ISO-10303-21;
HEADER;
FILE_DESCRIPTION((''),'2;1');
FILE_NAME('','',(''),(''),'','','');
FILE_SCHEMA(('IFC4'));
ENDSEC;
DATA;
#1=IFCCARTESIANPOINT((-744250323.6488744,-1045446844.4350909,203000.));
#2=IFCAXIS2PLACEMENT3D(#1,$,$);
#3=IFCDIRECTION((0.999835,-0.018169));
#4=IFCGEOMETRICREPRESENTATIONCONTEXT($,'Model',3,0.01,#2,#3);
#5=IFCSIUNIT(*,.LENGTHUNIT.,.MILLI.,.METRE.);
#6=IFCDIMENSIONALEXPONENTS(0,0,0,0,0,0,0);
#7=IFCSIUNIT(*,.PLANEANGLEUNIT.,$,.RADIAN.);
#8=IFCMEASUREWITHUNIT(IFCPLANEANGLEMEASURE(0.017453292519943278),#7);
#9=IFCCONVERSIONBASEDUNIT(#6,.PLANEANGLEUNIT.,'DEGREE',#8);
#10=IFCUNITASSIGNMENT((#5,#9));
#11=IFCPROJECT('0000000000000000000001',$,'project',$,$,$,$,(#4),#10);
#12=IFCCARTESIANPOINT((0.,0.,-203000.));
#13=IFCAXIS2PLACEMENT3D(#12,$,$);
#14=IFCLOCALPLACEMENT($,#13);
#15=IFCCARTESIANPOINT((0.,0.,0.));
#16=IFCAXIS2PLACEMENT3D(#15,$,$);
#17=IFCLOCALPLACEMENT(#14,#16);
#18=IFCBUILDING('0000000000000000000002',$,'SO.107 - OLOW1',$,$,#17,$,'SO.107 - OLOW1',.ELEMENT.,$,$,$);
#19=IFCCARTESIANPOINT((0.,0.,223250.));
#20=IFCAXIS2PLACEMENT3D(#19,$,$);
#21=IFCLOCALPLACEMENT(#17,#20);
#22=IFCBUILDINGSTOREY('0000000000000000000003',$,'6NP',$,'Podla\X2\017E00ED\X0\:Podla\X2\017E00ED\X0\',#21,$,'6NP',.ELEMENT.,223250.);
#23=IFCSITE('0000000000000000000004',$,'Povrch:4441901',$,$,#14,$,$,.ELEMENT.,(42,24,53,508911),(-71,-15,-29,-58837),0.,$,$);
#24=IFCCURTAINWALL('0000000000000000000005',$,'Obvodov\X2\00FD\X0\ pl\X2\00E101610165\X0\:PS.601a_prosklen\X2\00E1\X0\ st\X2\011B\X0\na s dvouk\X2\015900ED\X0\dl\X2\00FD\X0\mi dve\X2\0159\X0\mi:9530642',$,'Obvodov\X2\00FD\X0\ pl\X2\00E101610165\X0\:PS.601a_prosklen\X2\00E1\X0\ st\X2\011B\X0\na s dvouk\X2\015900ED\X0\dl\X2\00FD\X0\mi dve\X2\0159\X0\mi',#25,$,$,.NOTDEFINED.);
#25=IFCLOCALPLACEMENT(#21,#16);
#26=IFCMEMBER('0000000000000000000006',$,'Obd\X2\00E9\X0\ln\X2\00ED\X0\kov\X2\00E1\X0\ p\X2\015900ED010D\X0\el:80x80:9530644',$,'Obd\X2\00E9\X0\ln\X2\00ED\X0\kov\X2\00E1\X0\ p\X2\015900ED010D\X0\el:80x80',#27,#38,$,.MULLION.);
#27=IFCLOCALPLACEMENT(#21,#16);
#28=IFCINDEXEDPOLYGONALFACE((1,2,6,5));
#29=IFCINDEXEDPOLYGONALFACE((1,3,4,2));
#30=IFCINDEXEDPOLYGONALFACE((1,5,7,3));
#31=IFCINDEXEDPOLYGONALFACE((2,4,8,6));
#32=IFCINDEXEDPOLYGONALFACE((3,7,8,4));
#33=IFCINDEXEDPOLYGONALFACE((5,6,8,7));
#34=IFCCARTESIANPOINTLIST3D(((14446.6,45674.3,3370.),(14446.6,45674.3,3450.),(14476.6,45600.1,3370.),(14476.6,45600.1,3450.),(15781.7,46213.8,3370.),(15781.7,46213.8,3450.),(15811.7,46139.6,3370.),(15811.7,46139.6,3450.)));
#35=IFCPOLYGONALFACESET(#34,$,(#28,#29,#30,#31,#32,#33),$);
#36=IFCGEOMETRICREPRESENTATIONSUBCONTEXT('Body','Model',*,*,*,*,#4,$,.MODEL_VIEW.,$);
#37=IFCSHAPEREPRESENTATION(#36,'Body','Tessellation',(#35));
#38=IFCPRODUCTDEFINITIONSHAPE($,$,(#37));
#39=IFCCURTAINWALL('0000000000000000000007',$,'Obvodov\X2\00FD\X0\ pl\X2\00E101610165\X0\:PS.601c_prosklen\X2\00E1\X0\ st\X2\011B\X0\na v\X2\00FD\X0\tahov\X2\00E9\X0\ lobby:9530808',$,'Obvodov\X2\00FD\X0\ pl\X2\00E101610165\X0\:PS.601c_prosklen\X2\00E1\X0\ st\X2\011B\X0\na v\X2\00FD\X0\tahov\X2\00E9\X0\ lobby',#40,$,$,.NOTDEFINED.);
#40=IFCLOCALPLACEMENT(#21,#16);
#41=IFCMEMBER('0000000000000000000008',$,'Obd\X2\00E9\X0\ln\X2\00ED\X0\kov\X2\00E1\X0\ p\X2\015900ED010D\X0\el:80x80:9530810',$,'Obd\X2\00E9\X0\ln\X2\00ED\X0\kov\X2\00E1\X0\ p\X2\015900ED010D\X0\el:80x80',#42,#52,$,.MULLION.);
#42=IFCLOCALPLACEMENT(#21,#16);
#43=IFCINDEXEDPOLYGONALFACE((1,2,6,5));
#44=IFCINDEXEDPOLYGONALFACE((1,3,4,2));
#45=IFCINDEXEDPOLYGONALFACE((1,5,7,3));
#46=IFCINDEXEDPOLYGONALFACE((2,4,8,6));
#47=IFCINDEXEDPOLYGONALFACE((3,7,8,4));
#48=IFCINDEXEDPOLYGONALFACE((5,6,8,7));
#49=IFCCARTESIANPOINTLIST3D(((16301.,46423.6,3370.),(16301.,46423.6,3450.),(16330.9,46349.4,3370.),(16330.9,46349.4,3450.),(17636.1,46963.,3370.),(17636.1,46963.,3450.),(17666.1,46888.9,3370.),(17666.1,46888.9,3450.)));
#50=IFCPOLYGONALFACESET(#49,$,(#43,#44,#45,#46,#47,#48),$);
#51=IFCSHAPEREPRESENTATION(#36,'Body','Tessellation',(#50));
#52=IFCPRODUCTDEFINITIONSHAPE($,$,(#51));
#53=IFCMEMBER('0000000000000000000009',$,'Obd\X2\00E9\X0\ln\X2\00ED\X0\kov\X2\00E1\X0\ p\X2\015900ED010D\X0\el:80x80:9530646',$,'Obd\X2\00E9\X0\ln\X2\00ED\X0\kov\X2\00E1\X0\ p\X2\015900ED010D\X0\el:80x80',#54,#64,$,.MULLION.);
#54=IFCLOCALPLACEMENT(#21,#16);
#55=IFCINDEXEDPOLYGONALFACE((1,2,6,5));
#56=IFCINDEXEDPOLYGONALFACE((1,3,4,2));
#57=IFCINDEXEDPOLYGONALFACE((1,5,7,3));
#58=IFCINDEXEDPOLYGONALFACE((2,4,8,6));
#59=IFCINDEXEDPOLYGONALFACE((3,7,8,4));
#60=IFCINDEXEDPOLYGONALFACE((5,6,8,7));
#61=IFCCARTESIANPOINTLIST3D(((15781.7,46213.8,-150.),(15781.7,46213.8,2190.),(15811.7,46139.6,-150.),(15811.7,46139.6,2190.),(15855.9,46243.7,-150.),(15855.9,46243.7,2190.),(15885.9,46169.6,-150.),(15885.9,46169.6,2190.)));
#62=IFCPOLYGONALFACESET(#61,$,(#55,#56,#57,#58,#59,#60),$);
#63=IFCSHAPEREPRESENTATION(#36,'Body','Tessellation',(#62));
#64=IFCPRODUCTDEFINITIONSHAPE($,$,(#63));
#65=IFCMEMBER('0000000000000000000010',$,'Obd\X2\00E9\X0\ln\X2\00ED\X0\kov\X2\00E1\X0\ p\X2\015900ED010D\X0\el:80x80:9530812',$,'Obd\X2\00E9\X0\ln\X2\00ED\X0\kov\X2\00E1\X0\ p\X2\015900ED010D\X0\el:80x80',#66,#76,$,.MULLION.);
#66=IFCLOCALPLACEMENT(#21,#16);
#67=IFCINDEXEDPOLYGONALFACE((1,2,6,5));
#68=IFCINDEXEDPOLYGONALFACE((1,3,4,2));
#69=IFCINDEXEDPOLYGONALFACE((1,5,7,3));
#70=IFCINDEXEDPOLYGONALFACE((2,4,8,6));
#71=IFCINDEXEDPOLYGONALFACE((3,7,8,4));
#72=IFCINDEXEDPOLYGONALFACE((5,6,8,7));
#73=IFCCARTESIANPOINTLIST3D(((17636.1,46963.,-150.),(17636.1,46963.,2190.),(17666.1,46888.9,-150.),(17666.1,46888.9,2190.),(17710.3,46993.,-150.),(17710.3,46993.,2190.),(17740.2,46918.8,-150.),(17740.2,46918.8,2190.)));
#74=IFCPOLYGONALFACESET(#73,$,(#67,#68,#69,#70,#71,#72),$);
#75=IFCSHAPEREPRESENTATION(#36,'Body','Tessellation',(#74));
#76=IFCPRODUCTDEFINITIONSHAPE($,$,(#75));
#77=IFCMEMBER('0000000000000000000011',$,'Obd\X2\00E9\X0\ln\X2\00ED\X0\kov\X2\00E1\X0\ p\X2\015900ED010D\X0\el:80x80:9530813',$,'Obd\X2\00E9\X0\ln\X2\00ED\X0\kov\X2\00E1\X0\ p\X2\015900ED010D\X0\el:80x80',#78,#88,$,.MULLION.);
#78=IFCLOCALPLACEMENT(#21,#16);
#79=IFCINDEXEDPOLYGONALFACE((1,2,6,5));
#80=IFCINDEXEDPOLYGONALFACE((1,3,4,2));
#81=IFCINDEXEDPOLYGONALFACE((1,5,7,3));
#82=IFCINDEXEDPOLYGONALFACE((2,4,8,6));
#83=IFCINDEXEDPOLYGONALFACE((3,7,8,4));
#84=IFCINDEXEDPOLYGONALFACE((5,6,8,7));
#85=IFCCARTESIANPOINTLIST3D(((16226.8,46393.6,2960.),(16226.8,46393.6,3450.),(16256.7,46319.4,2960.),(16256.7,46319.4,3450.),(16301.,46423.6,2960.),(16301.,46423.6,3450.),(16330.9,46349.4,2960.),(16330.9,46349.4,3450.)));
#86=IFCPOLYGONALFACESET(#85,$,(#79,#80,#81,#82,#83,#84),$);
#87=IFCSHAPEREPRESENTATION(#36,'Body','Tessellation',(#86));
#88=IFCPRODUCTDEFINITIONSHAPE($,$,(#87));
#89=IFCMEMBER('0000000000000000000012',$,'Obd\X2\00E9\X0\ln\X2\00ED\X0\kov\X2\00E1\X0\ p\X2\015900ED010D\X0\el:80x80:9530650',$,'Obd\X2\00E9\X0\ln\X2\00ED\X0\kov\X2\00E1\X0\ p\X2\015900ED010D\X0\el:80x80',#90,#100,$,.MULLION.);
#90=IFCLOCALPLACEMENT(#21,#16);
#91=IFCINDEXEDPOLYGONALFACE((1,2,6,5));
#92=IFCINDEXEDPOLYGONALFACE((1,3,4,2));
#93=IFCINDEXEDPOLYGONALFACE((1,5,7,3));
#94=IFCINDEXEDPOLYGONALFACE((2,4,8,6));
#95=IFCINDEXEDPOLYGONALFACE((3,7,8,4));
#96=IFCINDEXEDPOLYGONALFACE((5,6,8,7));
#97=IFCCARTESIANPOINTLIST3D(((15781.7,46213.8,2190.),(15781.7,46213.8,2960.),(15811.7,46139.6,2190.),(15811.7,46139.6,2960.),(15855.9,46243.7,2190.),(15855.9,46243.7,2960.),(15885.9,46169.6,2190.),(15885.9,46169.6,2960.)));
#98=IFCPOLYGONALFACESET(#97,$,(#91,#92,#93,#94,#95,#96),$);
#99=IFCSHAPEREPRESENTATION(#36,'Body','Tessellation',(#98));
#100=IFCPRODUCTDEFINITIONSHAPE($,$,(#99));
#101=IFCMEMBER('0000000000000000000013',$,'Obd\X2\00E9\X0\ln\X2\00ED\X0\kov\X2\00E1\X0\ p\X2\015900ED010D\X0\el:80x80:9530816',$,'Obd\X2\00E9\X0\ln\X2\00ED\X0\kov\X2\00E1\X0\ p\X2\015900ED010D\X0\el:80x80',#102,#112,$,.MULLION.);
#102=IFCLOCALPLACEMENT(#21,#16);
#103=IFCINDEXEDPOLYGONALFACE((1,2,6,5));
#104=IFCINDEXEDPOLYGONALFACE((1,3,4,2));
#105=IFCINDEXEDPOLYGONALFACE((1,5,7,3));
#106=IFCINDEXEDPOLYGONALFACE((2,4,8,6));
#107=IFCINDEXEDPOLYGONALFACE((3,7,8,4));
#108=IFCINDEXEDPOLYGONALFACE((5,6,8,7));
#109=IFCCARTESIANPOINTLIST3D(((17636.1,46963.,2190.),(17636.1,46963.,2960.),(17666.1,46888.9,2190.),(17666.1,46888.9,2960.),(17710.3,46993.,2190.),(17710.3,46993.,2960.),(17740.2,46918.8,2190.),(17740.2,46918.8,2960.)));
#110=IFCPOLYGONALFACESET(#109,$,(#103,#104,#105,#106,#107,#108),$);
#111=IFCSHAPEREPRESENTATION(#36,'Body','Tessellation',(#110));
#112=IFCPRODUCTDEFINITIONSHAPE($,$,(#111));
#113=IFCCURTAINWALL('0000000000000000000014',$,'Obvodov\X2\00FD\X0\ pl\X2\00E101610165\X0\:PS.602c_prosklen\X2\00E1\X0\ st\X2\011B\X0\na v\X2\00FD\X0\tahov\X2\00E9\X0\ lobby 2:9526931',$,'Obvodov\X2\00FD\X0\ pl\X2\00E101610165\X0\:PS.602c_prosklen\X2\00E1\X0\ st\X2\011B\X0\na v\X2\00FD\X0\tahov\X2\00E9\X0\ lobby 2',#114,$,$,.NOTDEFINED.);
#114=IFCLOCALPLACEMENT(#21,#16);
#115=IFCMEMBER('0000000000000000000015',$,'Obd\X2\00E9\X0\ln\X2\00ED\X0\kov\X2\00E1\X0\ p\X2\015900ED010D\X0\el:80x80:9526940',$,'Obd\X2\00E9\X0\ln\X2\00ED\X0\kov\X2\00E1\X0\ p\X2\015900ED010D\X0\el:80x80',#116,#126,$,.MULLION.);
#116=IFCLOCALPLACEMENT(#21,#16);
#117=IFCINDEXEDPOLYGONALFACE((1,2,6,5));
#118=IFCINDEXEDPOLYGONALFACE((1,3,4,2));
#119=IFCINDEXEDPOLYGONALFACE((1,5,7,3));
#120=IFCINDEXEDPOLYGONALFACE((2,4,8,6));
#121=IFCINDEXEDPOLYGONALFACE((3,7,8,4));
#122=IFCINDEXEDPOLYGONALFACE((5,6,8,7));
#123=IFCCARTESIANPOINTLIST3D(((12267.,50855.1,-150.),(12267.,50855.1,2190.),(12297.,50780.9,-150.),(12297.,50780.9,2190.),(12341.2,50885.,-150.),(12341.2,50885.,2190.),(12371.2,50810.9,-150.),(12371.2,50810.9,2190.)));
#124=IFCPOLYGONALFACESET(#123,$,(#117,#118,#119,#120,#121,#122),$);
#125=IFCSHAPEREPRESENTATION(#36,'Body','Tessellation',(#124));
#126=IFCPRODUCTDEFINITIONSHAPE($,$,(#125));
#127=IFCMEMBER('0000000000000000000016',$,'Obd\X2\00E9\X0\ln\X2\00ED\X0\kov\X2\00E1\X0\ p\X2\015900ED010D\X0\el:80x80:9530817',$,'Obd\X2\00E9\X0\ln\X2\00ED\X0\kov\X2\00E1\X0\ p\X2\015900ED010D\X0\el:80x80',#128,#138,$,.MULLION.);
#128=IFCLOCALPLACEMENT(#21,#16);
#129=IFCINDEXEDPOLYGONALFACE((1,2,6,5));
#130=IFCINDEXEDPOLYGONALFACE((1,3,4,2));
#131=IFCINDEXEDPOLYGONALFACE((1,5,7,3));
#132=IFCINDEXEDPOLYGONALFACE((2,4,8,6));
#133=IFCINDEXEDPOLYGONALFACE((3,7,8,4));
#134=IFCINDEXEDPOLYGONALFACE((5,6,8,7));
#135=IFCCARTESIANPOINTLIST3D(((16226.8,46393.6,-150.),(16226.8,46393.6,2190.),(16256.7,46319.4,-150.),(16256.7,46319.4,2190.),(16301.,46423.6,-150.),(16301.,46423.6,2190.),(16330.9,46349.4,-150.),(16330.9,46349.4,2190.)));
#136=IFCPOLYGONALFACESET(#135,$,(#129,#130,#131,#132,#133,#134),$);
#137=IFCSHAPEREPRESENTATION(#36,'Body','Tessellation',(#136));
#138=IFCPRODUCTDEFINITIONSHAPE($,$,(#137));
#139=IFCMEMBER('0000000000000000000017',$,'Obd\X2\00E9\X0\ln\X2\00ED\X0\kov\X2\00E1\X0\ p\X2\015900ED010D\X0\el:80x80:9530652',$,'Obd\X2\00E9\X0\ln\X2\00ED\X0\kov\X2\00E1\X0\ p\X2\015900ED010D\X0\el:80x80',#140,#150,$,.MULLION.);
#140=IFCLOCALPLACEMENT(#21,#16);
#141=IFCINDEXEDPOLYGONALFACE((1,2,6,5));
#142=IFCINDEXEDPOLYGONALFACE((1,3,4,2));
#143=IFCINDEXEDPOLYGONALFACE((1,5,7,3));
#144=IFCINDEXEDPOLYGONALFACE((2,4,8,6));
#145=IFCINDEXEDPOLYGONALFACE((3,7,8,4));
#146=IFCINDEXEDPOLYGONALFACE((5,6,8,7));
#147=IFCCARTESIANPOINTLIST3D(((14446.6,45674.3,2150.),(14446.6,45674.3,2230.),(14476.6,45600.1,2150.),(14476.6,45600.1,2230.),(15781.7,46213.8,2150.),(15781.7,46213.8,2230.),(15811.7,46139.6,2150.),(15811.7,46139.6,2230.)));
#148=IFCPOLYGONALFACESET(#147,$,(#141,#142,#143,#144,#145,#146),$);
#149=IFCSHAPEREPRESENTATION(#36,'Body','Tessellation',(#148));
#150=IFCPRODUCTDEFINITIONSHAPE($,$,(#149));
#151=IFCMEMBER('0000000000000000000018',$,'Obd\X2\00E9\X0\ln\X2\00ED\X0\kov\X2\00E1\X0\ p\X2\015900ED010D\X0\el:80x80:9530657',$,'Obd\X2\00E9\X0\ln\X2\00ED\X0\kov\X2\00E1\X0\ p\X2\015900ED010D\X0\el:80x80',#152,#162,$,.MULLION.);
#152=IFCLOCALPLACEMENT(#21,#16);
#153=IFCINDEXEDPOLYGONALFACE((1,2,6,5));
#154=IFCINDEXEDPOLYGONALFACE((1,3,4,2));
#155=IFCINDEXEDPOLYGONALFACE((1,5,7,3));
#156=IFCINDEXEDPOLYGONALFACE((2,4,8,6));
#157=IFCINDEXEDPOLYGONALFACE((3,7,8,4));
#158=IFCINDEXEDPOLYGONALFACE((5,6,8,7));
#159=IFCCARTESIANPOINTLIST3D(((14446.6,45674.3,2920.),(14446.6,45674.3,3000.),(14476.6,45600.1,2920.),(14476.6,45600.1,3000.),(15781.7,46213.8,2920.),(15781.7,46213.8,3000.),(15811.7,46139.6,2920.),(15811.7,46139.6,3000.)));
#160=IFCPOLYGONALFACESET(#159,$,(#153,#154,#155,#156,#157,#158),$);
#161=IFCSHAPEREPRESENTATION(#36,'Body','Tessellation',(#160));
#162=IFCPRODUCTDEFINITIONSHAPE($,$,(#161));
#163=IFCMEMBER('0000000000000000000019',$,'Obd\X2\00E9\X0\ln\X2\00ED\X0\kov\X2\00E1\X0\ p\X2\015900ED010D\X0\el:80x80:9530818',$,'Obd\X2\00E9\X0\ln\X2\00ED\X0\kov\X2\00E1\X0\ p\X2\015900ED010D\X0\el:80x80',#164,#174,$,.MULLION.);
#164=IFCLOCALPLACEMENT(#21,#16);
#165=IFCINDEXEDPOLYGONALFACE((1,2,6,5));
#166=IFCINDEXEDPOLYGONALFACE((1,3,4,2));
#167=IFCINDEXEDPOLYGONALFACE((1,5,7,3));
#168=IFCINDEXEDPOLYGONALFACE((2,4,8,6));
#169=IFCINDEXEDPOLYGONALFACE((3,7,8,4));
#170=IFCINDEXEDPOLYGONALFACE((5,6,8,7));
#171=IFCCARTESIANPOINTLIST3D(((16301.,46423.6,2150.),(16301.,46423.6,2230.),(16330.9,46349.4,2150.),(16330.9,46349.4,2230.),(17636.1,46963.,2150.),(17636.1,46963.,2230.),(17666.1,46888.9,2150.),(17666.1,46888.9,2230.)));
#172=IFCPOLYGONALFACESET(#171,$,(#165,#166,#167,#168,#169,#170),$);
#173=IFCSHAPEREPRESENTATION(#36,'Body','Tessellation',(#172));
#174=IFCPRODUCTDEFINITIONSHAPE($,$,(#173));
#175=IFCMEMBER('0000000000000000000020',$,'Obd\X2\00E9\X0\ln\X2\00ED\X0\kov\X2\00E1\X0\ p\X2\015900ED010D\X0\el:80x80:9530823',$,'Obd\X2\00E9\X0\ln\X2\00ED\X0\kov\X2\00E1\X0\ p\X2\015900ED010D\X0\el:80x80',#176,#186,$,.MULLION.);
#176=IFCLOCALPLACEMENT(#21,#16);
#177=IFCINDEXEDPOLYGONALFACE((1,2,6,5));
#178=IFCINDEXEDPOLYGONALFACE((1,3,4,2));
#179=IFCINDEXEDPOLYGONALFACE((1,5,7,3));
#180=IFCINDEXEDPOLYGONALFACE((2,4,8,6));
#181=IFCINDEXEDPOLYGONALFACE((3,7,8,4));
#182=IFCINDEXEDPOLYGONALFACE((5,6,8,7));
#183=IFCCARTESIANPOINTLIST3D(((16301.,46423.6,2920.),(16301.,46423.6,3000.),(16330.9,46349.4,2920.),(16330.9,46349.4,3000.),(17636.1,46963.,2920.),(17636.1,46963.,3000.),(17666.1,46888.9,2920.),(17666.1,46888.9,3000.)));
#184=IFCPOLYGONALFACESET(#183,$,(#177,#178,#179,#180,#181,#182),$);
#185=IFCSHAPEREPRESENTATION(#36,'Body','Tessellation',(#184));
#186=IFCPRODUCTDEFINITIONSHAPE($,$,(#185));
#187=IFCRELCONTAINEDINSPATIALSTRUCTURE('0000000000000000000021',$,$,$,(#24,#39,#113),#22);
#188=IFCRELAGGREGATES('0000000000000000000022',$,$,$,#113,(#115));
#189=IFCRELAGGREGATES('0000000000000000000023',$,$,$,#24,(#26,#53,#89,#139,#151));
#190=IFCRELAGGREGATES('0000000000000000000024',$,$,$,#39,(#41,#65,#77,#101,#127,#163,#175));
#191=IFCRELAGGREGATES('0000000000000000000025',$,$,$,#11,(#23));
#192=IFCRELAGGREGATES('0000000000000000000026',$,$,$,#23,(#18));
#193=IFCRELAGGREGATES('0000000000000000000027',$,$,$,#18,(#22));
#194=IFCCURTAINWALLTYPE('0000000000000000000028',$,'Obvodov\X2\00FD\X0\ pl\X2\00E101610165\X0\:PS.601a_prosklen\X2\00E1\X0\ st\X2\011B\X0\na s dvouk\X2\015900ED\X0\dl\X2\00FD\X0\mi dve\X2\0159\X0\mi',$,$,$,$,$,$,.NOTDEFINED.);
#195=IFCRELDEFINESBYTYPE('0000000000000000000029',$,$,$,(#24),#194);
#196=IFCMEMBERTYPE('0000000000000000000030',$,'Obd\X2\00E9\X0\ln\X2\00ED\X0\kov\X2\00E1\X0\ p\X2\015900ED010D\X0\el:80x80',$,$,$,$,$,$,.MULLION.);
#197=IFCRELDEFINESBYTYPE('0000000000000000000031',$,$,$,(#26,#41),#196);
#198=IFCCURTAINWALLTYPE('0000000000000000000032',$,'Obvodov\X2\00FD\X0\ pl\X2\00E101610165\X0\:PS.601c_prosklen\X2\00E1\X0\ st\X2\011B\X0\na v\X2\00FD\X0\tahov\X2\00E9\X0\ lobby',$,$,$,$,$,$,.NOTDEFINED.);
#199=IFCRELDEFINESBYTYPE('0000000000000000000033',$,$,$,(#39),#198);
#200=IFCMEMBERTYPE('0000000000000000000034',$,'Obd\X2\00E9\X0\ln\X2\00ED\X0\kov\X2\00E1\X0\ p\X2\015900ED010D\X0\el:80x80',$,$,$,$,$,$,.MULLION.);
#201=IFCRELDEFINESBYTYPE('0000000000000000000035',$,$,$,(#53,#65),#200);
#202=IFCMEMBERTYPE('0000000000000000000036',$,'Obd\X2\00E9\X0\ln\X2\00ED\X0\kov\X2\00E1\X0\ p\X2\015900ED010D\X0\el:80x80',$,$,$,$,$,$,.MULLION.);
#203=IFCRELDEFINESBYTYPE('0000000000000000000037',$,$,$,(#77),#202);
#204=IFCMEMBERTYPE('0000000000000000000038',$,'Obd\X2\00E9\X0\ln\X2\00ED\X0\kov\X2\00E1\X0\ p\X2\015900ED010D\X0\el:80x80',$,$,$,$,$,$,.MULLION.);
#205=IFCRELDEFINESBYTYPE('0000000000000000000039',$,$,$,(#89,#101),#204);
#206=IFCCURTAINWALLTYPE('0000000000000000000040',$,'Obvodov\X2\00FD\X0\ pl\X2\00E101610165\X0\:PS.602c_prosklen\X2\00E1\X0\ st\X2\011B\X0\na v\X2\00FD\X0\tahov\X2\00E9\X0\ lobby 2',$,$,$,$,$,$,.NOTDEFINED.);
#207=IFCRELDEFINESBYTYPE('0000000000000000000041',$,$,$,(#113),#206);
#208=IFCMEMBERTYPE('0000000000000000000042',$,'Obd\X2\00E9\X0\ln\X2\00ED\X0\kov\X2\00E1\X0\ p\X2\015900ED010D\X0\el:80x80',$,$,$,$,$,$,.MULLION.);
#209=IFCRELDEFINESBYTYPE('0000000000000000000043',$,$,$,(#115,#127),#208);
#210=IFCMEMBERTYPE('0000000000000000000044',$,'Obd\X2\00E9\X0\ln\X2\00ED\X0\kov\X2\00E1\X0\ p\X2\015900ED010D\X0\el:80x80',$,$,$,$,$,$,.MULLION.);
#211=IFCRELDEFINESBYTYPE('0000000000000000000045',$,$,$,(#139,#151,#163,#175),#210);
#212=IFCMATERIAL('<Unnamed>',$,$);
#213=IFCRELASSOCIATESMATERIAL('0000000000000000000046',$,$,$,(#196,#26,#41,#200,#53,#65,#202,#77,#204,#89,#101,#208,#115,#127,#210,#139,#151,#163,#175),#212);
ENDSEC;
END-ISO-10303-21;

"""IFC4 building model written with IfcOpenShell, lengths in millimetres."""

from ifc_helpers import new_model, entity, si_unit, converted_unit, direction, frame, origin, place, context, subcontext, project, spatial, indexed_curve, outline, extrude, source, transform, mapped, material, type_object, type_shapes, element, aggregate, save


model = new_model("IFC4")

# Units and contexts
model_context = context("Model", 3, precision=0.01, world=frame((-744250323.6488744, -1045446844.4350909, 203000.0)), true_north=direction((0.999835, -0.018169)))
body_context = subcontext(model_context, "Body", "Model", "MODEL_VIEW")
ifc_project = project(units=[si_unit("LENGTHUNIT", "METRE", prefix="MILLI"), converted_unit("PLANEANGLEUNIT", "DEGREE", entity("IfcPlaneAngleMeasure", 0.017453292519943278), si_unit("PLANEANGLEUNIT", "RADIAN"), dimensions=[0, 0, 0, 0, 0, 0, 0])], contexts=[model_context])

# Site, building, storey
site_placement = place(None, frame((0.0, 0.0, -203000.0)))
site = spatial("IfcSite", under=ifc_project, at=site_placement, Name="Povrch:4441901", CompositionType="ELEMENT", RefLatitude=(42, 24, 53, 508911), RefLongitude=(-71, -15, -29, -58837), RefElevation=0.0)
building_placement = place(site_placement, origin())
building = spatial("IfcBuilding", under=site, at=building_placement, Name="SO.107 - OLOW1", LongName="SO.107 - OLOW1", CompositionType="ELEMENT")
storey_placement = place(building_placement, frame((0.0, 0.0, 223250.0)))
storey = spatial("IfcBuildingStorey", under=building, at=storey_placement, Name="6NP", ObjectType="Podlaží:Podlaží", LongName="6NP", CompositionType="ELEMENT", Elevation=223250.0)

# Curtain walls, members
curtain_wall_type_1 = type_object("IfcCurtainWallType", Name="Obvodový plášť:PS.601a_prosklená stěna s dvoukřídlými dveřmi", PredefinedType="NOTDEFINED")
curtain_wall_1_placement = place(storey_placement, frame((0.0, 0.0, -223250.0)))
curtain_wall_1 = element("IfcCurtainWall", 1, at=curtain_wall_1_placement, inside=storey, type_object=curtain_wall_type_1, Name="Obvodový plášť:PS.601a_prosklená stěna s dvoukřídlými dveřmi:9530642", ObjectType="Obvodový plášť:PS.601a_prosklená stěna s dvoukřídlými dveřmi", PredefinedType="NOTDEFINED")
ifc_material_1 = material(Name="<Unnamed>")
member_type_1 = type_object("IfcMemberType", Name="Obdélníková příčel:80x80", PredefinedType="MULLION", material=ifc_material_1)
shared_shape_1 = source(origin(), body_context, "Body", "SweptSolid", [
    extrude(outline(indexed_curve([(-40.0, -40.0), (40.0, -40.0), (40.0, 40.0), (-40.0, 40.0), (-40.0, -40.0)], self_intersect=False)), frame((-40.0, 0.0, -1440.0), z_axis=(0.0, 0.0, 1.0), x_axis=(-1.0, 0.0, 0.0)), (0.0, 0.0, 1.0), 1440.0),
])
type_shapes(member_type_1, [shared_shape_1])
member_1_placement = place(curtain_wall_1_placement, frame((15796.7, 46176.7, 226700.0), z_axis=(0.927176, 0.374626, 0.0), x_axis=(0.0, 0.0, 1.0)))
member_1 = element("IfcMember", 2, at=member_1_placement, type_object=member_type_1, material=ifc_material_1, Name="Obdélníková příčel:80x80:9530644", ObjectType="Obdélníková příčel:80x80", PredefinedType="MULLION", context=body_context, shape_type="MappedRepresentation", body=[
    mapped(shared_shape_1, transform((0.0, 0.0, 0.0), scale=1.0)),
])
curtain_wall_type_2 = type_object("IfcCurtainWallType", Name="Obvodový plášť:PS.601c_prosklená stěna výtahové lobby", PredefinedType="NOTDEFINED")
curtain_wall_2_placement = place(storey_placement, frame((0.0, 0.0, -223250.0)))
curtain_wall_2 = element("IfcCurtainWall", 3, at=curtain_wall_2_placement, inside=storey, type_object=curtain_wall_type_2, Name="Obvodový plášť:PS.601c_prosklená stěna výtahové lobby:9530808", ObjectType="Obvodový plášť:PS.601c_prosklená stěna výtahové lobby", PredefinedType="NOTDEFINED")
member_2_placement = place(curtain_wall_2_placement, frame((17651.1, 46925.9, 226700.0), z_axis=(0.927176, 0.374626, 0.0), x_axis=(0.0, 0.0, 1.0)))
member_2 = element("IfcMember", 4, at=member_2_placement, type_object=member_type_1, material=ifc_material_1, Name="Obdélníková příčel:80x80:9530810", ObjectType="Obdélníková příčel:80x80", PredefinedType="MULLION", context=body_context, shape_type="MappedRepresentation", body=[
    mapped(shared_shape_1, transform((0.0, 0.0, 0.0), scale=1.0)),
])

# Members
member_type_2 = type_object("IfcMemberType", Name="Obdélníková příčel:80x80", PredefinedType="MULLION", material=ifc_material_1)
shared_shape_2 = source(origin(), body_context, "Body", "SweptSolid", [
    extrude(outline(indexed_curve([(-40.0, -40.0), (40.0, -40.0), (40.0, 40.0), (-40.0, 40.0), (-40.0, -40.0)], self_intersect=False)), frame((-40.0, 0.0, -2340.0), z_axis=(0.0, 0.0, 1.0), x_axis=(-1.0, 0.0, 0.0)), (0.0, 0.0, 1.0), 2340.0),
])
type_shapes(member_type_2, [shared_shape_2])
member_3_placement = place(curtain_wall_1_placement, frame((15870.9, 46206.7, 223100.0), z_axis=(0.0, 0.0, -1.0), x_axis=(0.927176, 0.374626, 0.0)))
member_3 = element("IfcMember", 5, at=member_3_placement, type_object=member_type_2, material=ifc_material_1, Name="Obdélníková příčel:80x80:9530646", ObjectType="Obdélníková příčel:80x80", PredefinedType="MULLION", context=body_context, shape_type="MappedRepresentation", body=[
    mapped(shared_shape_2, transform((0.0, 0.0, 0.0), scale=1.0)),
])
member_4_placement = place(curtain_wall_2_placement, frame((17725.2, 46955.9, 223100.0), z_axis=(0.0, 0.0, -1.0), x_axis=(0.927176, 0.374626, 0.0)))
member_4 = element("IfcMember", 6, at=member_4_placement, type_object=member_type_2, material=ifc_material_1, Name="Obdélníková příčel:80x80:9530812", ObjectType="Obdélníková příčel:80x80", PredefinedType="MULLION", context=body_context, shape_type="MappedRepresentation", body=[
    mapped(shared_shape_2, transform((0.0, 0.0, 0.0), scale=1.0)),
])
member_type_3 = type_object("IfcMemberType", Name="Obdélníková příčel:80x80", PredefinedType="MULLION", material=ifc_material_1)
shared_shape_3 = source(origin(), body_context, "Body", "SweptSolid", [
    extrude(outline(indexed_curve([(-40.0, -40.0), (40.0, -40.0), (40.0, 40.0), (-40.0, 40.0), (-40.0, -40.0)], self_intersect=False)), frame((-40.0, 0.0, -490.0), z_axis=(0.0, 0.0, 1.0), x_axis=(-1.0, 0.0, 0.0)), (0.0, 0.0, 1.0), 490.0),
])
type_shapes(member_type_3, [shared_shape_3])
member_5_placement = place(curtain_wall_2_placement, frame((16241.8, 46356.5, 226700.0), z_axis=(0.0, 0.0, 1.0), x_axis=(-0.927176, -0.374626, 0.0)))
member_5 = element("IfcMember", 7, at=member_5_placement, type_object=member_type_3, material=ifc_material_1, Name="Obdélníková příčel:80x80:9530813", ObjectType="Obdélníková příčel:80x80", PredefinedType="MULLION", context=body_context, shape_type="MappedRepresentation", body=[
    mapped(shared_shape_3, transform((0.0, 0.0, 0.0), scale=1.0)),
])
member_type_4 = type_object("IfcMemberType", Name="Obdélníková příčel:80x80", PredefinedType="MULLION", material=ifc_material_1)
shared_shape_4 = source(origin(), body_context, "Body", "SweptSolid", [
    extrude(outline(indexed_curve([(-40.0, -40.0), (40.0, -40.0), (40.0, 40.0), (-40.0, 40.0), (-40.0, -40.0)], self_intersect=False)), frame((-40.0, 0.0, -770.0), z_axis=(0.0, 0.0, 1.0), x_axis=(-1.0, 0.0, 0.0)), (0.0, 0.0, 1.0), 770.0),
])
type_shapes(member_type_4, [shared_shape_4])
member_6_placement = place(curtain_wall_1_placement, frame((15870.9, 46206.7, 225440.0), z_axis=(0.0, 0.0, -1.0), x_axis=(0.927176, 0.374626, 0.0)))
member_6 = element("IfcMember", 8, at=member_6_placement, type_object=member_type_4, material=ifc_material_1, Name="Obdélníková příčel:80x80:9530650", ObjectType="Obdélníková příčel:80x80", PredefinedType="MULLION", context=body_context, shape_type="MappedRepresentation", body=[
    mapped(shared_shape_4, transform((0.0, 0.0, 0.0), scale=1.0)),
])
member_7_placement = place(curtain_wall_2_placement, frame((17725.2, 46955.9, 225440.0), z_axis=(0.0, 0.0, -1.0), x_axis=(0.927176, 0.374626, 0.0)))
member_7 = element("IfcMember", 9, at=member_7_placement, type_object=member_type_4, material=ifc_material_1, Name="Obdélníková příčel:80x80:9530816", ObjectType="Obdélníková příčel:80x80", PredefinedType="MULLION", context=body_context, shape_type="MappedRepresentation", body=[
    mapped(shared_shape_4, transform((0.0, 0.0, 0.0), scale=1.0)),
])

# Curtain wall, member
curtain_wall_type_3 = type_object("IfcCurtainWallType", Name="Obvodový plášť:PS.602c_prosklená stěna výtahové lobby 2", PredefinedType="NOTDEFINED")
curtain_wall_3_placement = place(storey_placement, frame((0.0, 0.0, -223250.0)))
curtain_wall_3 = element("IfcCurtainWall", 10, at=curtain_wall_3_placement, inside=storey, type_object=curtain_wall_type_3, Name="Obvodový plášť:PS.602c_prosklená stěna výtahové lobby 2:9526931", ObjectType="Obvodový plášť:PS.602c_prosklená stěna výtahové lobby 2", PredefinedType="NOTDEFINED")
member_type_5 = type_object("IfcMemberType", Name="Obdélníková příčel:80x80", PredefinedType="MULLION", material=ifc_material_1)
shared_shape_5 = source(origin(), body_context, "Body", "SweptSolid", [
    extrude(outline(indexed_curve([(-40.0, -40.0), (40.0, -40.0), (40.0, 40.0), (-40.0, 40.0), (-40.0, -40.0)], self_intersect=False)), frame((-40.0, 0.0, -2340.0), z_axis=(0.0, 0.0, 1.0), x_axis=(-1.0, 0.0, 0.0)), (0.0, 0.0, 1.0), 2340.0),
])
type_shapes(member_type_5, [shared_shape_5])
member_8_placement = place(curtain_wall_3_placement, frame((12282.0, 50818.0, 225440.0), z_axis=(0.0, 0.0, 1.0), x_axis=(-0.927176, -0.374626, 0.0)))
member_8 = element("IfcMember", 11, at=member_8_placement, type_object=member_type_5, material=ifc_material_1, Name="Obdélníková příčel:80x80:9526940", ObjectType="Obdélníková příčel:80x80", PredefinedType="MULLION", context=body_context, shape_type="MappedRepresentation", body=[
    mapped(shared_shape_5, transform((0.0, 0.0, 0.0), scale=1.0)),
])
aggregate(curtain_wall_3, [member_8])

# Members
member_9_placement = place(curtain_wall_2_placement, frame((16241.8, 46356.5, 225440.0), z_axis=(0.0, 0.0, 1.0), x_axis=(-0.927176, -0.374626, 0.0)))
member_9 = element("IfcMember", 12, at=member_9_placement, type_object=member_type_5, material=ifc_material_1, Name="Obdélníková příčel:80x80:9530817", ObjectType="Obdélníková příčel:80x80", PredefinedType="MULLION", context=body_context, shape_type="MappedRepresentation", body=[
    mapped(shared_shape_5, transform((0.0, 0.0, 0.0), scale=1.0)),
])
member_type_6 = type_object("IfcMemberType", Name="Obdélníková příčel:80x80", PredefinedType="MULLION", material=ifc_material_1)
shared_shape_6 = source(origin(), body_context, "Body", "SweptSolid", [
    extrude(outline(indexed_curve([(-40.0, -40.0), (40.0, -40.0), (40.0, 40.0), (-40.0, 40.0), (-40.0, -40.0)], self_intersect=False)), frame((0.0, 0.0, -1440.0), z_axis=(0.0, 0.0, 1.0), x_axis=(-1.0, 0.0, 0.0)), (0.0, 0.0, 1.0), 1440.0),
])
type_shapes(member_type_6, [shared_shape_6])
member_10_placement = place(curtain_wall_1_placement, frame((15796.7, 46176.7, 225440.0), z_axis=(0.927176, 0.374626, 0.0), x_axis=(0.0, 0.0, 1.0)))
member_10 = element("IfcMember", 13, at=member_10_placement, type_object=member_type_6, material=ifc_material_1, Name="Obdélníková příčel:80x80:9530652", ObjectType="Obdélníková příčel:80x80", PredefinedType="MULLION", context=body_context, shape_type="MappedRepresentation", body=[
    mapped(shared_shape_6, transform((0.0, 0.0, 0.0), scale=1.0)),
])
member_11_placement = place(curtain_wall_1_placement, frame((15796.7, 46176.7, 226210.0), z_axis=(0.927176, 0.374626, 0.0), x_axis=(0.0, 0.0, 1.0)))
member_11 = element("IfcMember", 14, at=member_11_placement, type_object=member_type_6, material=ifc_material_1, Name="Obdélníková příčel:80x80:9530657", ObjectType="Obdélníková příčel:80x80", PredefinedType="MULLION", context=body_context, shape_type="MappedRepresentation", body=[
    mapped(shared_shape_6, transform((0.0, 0.0, 0.0), scale=1.0)),
])
member_12_placement = place(curtain_wall_2_placement, frame((17651.1, 46925.9, 225440.0), z_axis=(0.927176, 0.374626, 0.0), x_axis=(0.0, 0.0, 1.0)))
member_12 = element("IfcMember", 15, at=member_12_placement, type_object=member_type_6, material=ifc_material_1, Name="Obdélníková příčel:80x80:9530818", ObjectType="Obdélníková příčel:80x80", PredefinedType="MULLION", context=body_context, shape_type="MappedRepresentation", body=[
    mapped(shared_shape_6, transform((0.0, 0.0, 0.0), scale=1.0)),
])
member_13_placement = place(curtain_wall_2_placement, frame((17651.1, 46925.9, 226210.0), z_axis=(0.927176, 0.374626, 0.0), x_axis=(0.0, 0.0, 1.0)))
member_13 = element("IfcMember", 16, at=member_13_placement, type_object=member_type_6, material=ifc_material_1, Name="Obdélníková příčel:80x80:9530823", ObjectType="Obdélníková příčel:80x80", PredefinedType="MULLION", context=body_context, shape_type="MappedRepresentation", body=[
    mapped(shared_shape_6, transform((0.0, 0.0, 0.0), scale=1.0)),
])

aggregate(curtain_wall_1, [member_1, member_3, member_6, member_10, member_11])
aggregate(curtain_wall_2, [member_2, member_4, member_5, member_7, member_9, member_12, member_13])

save(model, "model.ifc")
